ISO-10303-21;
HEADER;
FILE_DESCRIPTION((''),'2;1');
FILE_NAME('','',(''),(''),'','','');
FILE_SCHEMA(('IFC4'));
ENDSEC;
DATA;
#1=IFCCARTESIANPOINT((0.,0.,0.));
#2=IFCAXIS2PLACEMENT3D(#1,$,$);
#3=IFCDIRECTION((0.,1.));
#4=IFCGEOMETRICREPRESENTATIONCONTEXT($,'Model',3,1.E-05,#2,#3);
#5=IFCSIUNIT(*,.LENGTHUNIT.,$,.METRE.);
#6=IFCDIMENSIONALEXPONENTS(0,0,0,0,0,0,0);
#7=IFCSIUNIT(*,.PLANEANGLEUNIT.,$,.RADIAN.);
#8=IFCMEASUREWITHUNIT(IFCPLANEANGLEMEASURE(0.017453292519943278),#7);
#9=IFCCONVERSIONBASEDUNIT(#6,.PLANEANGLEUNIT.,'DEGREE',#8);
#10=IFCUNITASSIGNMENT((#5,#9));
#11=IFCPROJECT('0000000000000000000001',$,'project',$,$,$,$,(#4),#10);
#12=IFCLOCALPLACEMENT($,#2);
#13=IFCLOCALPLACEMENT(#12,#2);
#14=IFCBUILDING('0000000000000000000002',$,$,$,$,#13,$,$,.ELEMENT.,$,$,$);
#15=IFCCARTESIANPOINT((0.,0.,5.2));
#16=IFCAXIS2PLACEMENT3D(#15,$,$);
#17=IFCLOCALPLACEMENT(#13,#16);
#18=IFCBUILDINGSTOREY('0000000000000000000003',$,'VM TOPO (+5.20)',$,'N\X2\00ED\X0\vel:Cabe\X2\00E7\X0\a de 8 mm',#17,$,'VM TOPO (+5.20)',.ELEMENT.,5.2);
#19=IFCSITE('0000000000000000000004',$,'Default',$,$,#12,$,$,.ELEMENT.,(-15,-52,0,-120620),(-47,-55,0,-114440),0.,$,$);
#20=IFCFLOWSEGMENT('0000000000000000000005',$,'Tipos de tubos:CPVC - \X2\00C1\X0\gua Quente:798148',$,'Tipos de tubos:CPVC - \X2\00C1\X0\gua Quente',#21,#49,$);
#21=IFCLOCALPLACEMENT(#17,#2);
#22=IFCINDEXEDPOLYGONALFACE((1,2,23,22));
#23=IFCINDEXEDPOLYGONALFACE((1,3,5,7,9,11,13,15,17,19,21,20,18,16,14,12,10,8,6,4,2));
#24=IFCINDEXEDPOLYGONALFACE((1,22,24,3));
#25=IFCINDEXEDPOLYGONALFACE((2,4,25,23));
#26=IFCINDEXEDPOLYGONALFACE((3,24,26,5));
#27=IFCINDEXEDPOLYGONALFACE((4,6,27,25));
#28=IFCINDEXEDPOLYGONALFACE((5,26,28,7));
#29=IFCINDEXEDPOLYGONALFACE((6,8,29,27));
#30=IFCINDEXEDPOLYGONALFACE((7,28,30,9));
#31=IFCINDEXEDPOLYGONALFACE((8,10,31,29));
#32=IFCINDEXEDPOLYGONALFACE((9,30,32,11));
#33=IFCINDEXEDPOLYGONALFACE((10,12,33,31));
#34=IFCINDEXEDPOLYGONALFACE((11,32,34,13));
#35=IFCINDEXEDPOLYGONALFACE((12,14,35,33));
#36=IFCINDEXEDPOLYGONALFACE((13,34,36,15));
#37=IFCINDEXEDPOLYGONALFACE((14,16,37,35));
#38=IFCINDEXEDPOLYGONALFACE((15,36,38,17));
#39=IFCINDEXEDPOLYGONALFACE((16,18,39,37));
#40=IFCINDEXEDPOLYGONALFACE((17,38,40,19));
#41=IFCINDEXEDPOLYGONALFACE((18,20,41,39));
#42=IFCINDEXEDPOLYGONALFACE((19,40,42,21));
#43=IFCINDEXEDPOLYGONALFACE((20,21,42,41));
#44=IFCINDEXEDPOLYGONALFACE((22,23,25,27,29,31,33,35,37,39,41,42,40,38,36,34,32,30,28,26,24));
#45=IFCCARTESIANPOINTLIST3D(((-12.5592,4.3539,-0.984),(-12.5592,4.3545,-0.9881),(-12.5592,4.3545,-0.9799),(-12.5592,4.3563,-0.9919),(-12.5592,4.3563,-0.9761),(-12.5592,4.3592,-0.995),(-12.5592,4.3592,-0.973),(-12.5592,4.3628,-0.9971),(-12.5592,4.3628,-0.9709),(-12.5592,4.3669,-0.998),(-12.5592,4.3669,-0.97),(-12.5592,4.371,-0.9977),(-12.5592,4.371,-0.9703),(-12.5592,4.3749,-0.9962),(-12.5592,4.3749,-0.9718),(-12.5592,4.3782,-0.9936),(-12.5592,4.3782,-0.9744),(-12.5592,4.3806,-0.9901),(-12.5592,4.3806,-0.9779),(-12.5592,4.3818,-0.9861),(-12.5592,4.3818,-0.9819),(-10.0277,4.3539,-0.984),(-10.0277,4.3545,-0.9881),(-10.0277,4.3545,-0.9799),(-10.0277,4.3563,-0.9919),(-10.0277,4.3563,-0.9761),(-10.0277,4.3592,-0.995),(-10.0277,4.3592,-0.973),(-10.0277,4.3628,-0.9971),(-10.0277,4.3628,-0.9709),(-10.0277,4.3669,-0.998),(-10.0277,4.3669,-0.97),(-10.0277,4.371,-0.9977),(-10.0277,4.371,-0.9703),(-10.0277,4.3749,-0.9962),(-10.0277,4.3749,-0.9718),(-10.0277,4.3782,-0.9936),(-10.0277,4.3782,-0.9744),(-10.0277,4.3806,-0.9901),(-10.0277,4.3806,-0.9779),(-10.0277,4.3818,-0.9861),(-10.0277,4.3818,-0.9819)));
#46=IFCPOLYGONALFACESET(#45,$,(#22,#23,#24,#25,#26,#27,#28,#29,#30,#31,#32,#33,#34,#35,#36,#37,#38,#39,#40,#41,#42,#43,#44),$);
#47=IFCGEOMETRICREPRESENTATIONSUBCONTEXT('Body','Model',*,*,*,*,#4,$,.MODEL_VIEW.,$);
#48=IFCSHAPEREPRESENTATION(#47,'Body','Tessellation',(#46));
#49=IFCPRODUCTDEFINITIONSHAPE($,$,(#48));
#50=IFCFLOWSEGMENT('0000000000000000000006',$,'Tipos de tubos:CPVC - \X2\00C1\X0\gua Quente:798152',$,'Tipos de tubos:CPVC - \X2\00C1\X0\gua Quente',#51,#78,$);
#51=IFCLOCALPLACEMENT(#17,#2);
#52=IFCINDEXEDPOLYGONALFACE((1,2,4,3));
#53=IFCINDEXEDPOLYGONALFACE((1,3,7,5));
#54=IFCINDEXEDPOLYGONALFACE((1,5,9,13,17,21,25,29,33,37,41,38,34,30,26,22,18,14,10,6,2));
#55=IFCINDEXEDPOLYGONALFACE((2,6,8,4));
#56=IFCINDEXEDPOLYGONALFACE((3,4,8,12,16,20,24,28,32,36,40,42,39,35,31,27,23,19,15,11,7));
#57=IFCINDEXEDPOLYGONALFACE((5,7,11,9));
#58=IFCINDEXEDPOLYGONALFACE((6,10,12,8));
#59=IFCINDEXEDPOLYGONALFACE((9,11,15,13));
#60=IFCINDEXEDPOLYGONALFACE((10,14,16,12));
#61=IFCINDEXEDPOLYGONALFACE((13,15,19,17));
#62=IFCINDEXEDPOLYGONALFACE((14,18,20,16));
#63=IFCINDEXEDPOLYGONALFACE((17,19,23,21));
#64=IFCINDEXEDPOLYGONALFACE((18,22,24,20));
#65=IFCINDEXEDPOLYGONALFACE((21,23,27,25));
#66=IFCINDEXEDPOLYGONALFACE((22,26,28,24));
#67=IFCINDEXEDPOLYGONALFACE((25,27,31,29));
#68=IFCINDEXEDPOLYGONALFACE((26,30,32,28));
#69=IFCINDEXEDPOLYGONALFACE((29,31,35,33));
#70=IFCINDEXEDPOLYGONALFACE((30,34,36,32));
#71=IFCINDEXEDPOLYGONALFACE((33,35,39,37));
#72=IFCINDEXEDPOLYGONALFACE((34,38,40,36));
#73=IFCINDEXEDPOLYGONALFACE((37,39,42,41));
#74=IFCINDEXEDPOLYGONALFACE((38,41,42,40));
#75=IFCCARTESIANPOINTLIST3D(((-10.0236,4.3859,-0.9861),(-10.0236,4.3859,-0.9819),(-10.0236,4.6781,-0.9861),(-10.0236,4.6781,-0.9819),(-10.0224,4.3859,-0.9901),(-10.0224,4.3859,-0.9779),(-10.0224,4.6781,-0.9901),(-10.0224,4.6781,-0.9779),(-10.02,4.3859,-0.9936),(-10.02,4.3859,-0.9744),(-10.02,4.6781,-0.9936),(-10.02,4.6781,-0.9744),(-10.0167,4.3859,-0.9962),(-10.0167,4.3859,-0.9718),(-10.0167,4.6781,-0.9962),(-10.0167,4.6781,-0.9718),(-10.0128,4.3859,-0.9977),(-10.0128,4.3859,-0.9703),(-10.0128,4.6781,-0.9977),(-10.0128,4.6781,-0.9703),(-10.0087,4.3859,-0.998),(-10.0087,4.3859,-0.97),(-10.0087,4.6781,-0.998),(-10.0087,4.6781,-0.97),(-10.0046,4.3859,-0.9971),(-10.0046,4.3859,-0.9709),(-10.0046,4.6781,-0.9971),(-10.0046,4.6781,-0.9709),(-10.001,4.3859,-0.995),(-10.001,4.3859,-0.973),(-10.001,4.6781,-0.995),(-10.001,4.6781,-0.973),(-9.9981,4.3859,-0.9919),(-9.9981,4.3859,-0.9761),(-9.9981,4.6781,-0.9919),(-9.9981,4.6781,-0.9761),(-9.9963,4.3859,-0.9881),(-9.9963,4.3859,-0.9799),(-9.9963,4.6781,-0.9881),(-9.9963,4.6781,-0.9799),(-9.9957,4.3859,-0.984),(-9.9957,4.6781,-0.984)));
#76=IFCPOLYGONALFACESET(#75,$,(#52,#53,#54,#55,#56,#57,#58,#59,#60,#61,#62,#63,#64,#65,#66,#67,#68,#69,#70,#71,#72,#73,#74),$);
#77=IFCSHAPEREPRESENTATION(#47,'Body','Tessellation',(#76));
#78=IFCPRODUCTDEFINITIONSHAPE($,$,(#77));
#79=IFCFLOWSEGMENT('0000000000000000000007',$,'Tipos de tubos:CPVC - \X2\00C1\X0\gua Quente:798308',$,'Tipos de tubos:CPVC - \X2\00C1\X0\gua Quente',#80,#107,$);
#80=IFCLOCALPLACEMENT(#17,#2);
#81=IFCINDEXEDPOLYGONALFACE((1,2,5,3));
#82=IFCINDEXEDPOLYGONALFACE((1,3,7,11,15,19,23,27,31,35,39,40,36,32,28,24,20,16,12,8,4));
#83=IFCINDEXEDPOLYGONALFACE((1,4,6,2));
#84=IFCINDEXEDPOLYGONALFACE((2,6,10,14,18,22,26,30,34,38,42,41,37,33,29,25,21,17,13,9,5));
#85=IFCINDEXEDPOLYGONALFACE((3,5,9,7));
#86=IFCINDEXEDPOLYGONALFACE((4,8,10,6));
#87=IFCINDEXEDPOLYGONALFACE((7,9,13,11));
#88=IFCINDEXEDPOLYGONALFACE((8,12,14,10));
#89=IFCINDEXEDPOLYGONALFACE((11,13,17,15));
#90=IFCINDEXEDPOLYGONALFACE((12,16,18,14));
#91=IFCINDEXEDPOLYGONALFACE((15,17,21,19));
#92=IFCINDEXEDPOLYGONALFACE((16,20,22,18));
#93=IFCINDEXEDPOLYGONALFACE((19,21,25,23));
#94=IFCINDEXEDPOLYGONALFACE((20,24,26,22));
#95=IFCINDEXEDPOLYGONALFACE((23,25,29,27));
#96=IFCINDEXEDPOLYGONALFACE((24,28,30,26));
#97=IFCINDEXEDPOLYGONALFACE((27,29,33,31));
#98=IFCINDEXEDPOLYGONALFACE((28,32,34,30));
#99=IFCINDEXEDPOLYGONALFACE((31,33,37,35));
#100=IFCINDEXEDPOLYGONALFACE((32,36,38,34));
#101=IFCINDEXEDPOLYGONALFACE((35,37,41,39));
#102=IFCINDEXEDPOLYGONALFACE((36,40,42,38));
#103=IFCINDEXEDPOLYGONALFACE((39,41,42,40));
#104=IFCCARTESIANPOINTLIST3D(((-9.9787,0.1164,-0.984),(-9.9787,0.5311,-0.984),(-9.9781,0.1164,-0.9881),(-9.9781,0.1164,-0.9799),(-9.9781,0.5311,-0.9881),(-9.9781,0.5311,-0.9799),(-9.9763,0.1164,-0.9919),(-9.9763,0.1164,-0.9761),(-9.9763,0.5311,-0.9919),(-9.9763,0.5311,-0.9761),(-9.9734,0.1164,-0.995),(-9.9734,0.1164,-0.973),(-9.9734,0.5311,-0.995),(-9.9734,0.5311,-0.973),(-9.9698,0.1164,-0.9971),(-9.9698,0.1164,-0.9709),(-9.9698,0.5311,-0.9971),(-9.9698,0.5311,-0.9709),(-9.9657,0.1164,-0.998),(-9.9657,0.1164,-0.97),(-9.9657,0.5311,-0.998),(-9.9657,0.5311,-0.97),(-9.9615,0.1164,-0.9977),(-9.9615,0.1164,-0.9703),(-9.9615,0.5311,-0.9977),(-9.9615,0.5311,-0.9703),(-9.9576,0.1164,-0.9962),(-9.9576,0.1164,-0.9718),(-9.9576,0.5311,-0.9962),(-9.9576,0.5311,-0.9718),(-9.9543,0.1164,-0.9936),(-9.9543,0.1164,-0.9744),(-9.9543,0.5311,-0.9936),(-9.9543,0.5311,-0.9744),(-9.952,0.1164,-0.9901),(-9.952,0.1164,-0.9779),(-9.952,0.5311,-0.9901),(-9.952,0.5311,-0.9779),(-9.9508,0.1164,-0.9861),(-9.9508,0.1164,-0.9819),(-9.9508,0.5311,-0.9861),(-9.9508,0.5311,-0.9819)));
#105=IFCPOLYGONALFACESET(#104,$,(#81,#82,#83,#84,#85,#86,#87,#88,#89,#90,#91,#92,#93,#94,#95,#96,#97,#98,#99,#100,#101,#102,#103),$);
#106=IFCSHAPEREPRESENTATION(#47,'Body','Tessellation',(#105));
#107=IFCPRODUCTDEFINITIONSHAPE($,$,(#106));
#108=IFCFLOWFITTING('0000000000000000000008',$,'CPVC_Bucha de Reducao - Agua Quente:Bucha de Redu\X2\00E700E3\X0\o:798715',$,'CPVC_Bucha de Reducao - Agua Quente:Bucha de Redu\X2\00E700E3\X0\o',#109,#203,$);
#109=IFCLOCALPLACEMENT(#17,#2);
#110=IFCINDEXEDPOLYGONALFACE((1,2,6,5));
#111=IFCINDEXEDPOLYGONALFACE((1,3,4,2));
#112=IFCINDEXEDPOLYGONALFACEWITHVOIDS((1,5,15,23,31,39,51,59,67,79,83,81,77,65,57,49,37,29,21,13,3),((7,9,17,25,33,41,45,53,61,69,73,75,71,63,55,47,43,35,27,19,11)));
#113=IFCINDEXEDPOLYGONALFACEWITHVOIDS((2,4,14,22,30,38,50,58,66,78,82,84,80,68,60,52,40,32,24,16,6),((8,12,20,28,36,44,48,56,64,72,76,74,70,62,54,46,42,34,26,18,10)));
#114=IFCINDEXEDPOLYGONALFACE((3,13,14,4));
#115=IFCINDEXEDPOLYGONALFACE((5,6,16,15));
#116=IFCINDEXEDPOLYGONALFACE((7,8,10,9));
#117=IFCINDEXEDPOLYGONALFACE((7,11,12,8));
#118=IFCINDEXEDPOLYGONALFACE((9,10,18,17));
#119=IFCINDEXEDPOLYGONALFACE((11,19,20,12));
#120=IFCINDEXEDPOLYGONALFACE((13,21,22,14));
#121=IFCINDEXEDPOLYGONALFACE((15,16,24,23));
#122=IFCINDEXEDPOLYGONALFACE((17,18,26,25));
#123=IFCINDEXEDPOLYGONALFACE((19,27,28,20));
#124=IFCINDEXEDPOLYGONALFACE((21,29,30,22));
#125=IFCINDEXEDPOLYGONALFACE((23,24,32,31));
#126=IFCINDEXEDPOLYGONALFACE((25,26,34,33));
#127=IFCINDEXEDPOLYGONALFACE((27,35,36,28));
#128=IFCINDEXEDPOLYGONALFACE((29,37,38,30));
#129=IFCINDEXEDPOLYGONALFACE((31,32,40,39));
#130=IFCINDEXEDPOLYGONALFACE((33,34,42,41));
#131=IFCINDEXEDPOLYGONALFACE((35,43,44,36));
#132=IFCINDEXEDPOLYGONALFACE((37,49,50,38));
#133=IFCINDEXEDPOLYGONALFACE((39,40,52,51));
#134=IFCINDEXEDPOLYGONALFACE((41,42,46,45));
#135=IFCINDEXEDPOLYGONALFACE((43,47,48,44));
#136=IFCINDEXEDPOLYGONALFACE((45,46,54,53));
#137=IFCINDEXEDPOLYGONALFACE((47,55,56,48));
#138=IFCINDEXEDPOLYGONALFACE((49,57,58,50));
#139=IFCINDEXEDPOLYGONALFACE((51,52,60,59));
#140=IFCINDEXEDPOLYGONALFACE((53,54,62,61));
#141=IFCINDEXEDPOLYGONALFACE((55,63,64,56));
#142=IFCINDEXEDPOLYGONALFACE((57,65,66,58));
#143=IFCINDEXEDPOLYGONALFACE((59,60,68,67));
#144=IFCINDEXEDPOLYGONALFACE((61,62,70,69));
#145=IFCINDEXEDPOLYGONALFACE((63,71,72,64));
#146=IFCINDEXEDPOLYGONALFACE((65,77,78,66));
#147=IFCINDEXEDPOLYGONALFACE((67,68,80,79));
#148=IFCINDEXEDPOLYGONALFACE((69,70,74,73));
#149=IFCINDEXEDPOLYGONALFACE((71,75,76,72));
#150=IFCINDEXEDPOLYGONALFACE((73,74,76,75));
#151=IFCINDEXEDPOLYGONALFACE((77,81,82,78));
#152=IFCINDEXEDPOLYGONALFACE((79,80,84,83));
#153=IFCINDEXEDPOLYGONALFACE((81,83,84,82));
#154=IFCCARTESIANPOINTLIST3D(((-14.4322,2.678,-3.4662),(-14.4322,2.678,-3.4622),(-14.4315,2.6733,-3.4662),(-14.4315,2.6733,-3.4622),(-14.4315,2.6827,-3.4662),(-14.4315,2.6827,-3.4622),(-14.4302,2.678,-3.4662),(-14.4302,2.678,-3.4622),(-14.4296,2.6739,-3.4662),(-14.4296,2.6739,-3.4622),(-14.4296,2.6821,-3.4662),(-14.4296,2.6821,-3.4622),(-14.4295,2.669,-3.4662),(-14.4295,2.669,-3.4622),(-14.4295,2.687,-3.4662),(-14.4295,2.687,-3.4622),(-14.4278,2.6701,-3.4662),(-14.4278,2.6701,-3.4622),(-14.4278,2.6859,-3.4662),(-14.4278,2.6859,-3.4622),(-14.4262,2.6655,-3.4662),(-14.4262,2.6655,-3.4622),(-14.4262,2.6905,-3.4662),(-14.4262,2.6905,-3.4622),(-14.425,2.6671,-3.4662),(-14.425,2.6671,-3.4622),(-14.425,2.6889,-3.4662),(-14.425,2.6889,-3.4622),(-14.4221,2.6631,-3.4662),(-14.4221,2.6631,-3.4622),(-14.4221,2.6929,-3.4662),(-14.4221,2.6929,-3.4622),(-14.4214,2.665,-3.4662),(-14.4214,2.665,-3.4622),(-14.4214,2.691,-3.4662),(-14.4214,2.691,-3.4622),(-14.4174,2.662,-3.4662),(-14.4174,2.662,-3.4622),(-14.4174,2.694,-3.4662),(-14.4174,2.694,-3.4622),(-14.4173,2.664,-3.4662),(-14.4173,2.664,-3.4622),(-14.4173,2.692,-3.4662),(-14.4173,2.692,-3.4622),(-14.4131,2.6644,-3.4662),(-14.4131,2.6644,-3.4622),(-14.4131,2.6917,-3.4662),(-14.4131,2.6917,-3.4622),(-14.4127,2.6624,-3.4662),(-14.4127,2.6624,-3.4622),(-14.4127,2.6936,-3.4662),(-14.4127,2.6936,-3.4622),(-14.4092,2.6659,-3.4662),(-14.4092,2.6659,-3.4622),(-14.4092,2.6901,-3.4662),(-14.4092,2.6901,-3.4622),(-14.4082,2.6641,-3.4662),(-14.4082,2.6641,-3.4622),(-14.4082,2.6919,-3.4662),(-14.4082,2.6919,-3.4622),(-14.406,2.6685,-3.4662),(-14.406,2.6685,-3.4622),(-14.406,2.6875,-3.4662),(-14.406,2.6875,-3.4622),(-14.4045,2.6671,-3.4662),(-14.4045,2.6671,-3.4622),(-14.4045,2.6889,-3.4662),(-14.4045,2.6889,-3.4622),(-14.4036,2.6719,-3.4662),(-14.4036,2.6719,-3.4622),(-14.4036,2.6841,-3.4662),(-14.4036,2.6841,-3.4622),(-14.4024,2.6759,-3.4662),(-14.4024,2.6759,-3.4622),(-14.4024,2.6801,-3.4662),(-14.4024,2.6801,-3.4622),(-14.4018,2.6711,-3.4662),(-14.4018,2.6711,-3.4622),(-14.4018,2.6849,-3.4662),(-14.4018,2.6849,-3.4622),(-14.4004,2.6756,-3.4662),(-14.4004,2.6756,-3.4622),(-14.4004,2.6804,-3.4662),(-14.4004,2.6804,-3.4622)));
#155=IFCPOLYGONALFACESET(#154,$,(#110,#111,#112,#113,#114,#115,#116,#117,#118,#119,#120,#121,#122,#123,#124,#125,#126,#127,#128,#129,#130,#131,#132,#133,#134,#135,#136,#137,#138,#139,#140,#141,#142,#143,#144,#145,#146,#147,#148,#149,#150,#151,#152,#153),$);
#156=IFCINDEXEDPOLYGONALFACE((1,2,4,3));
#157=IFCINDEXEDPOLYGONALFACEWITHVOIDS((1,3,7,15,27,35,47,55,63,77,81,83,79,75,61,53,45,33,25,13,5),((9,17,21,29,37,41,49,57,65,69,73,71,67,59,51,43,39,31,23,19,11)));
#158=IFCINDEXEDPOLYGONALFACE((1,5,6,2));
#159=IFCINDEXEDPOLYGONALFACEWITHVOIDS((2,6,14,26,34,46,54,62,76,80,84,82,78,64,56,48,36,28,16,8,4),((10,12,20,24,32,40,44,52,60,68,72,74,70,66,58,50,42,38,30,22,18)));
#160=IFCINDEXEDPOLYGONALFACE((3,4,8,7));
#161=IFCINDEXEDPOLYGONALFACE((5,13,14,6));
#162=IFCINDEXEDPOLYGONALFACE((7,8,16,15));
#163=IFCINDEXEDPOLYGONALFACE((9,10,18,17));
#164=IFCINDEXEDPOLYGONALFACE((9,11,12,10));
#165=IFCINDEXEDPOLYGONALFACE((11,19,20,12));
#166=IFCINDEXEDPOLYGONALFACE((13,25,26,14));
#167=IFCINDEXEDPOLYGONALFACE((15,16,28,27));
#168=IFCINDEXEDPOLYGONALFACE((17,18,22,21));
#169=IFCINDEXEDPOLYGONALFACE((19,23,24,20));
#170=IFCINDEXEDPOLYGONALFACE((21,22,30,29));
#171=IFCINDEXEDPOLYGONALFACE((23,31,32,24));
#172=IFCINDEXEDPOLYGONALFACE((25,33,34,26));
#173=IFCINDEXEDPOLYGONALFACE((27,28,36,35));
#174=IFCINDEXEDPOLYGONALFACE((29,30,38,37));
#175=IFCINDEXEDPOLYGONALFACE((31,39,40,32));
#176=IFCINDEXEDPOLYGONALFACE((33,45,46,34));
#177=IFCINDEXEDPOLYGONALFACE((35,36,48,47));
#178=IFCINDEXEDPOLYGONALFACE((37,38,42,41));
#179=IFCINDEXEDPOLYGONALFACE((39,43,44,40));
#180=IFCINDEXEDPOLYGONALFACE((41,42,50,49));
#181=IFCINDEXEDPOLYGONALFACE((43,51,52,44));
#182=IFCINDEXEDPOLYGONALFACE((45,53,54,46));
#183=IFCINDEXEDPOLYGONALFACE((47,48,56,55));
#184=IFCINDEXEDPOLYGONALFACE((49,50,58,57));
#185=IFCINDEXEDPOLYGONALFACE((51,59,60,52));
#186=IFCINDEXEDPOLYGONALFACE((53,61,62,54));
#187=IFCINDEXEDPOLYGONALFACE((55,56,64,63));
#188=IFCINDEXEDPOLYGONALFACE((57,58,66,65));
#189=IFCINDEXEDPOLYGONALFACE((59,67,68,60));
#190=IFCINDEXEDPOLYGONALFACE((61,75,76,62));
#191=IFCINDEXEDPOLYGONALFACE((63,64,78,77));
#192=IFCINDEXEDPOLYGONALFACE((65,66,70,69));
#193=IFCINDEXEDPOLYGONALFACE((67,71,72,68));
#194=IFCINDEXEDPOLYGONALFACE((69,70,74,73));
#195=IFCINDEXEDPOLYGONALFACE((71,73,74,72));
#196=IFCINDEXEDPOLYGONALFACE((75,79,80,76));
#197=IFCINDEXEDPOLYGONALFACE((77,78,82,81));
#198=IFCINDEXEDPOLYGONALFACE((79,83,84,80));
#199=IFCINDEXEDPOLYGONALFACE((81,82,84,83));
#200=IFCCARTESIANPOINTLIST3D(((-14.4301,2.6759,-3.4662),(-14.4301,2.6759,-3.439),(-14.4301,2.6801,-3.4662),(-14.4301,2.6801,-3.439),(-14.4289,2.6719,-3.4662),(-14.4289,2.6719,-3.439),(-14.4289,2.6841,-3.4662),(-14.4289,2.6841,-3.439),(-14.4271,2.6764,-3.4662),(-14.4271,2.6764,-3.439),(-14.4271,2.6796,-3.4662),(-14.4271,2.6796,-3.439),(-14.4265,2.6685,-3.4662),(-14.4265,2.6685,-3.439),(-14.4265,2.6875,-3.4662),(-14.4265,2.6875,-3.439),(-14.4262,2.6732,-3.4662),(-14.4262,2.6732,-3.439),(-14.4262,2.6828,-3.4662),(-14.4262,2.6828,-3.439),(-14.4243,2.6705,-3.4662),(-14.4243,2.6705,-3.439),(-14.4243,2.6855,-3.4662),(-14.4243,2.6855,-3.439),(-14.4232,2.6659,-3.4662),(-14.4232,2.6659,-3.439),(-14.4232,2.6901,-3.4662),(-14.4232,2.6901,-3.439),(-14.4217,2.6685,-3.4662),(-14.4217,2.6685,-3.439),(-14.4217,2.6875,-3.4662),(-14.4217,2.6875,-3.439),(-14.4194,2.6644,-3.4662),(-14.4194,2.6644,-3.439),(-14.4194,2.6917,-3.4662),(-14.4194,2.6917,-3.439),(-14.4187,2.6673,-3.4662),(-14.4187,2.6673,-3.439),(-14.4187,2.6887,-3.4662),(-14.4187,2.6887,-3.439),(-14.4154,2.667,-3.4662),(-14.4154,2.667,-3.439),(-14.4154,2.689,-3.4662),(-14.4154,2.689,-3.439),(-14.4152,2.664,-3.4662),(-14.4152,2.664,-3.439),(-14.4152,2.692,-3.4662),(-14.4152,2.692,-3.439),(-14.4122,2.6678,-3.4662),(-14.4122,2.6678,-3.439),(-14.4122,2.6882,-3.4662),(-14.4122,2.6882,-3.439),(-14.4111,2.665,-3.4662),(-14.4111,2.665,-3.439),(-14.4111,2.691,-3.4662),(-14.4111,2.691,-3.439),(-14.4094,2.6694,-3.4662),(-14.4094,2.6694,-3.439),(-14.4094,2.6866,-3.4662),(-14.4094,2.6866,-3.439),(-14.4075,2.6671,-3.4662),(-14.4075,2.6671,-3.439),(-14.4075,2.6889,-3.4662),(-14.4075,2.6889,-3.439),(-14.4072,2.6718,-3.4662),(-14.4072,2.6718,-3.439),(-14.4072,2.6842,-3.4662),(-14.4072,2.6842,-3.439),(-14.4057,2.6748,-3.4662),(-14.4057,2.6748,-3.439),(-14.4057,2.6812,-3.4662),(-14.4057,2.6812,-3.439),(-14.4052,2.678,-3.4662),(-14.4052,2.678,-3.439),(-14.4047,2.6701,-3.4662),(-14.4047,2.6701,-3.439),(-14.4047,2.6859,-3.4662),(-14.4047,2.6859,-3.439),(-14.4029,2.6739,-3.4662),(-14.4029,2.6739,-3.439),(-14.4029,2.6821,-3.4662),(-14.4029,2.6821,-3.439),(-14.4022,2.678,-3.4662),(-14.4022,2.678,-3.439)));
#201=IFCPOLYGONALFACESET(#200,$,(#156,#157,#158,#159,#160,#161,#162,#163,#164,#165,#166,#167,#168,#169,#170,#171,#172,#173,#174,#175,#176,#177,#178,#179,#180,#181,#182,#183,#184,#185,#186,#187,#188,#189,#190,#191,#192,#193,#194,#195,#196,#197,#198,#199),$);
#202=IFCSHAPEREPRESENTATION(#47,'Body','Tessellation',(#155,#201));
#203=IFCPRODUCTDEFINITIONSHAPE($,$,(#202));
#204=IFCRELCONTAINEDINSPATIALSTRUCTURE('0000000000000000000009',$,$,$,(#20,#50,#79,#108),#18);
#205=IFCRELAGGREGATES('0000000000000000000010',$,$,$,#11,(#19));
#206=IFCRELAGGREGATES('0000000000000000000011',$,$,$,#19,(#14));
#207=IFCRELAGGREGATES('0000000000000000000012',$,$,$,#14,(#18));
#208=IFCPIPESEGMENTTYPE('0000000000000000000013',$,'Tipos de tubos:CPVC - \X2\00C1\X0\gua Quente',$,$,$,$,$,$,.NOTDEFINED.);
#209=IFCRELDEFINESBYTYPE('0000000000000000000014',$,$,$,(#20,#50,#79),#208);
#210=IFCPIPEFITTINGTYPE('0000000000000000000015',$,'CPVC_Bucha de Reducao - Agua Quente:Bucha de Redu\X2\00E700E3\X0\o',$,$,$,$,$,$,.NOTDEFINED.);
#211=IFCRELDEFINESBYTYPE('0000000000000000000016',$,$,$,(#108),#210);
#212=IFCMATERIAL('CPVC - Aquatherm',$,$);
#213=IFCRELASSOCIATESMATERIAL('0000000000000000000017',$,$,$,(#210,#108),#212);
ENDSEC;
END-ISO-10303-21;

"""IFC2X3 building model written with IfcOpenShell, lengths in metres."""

from ifc_helpers import new_model, entity, si_unit, converted_unit, direction, frame, frame_2d, origin, origin_2d_with_axis, place, context, subcontext, project, spatial, circle, hollow_circle, extrude, source, transform, mapped, material, type_object, type_shapes, element, save


model = new_model("IFC2X3")

# Units and contexts
model_context = context("Model", 3, precision=1e-05, world=origin(), true_north=direction((0.0, 1.0)))
body_context = subcontext(model_context, "Body", "Model", "MODEL_VIEW")
ifc_project = project(units=[si_unit("LENGTHUNIT", "METRE"), converted_unit("PLANEANGLEUNIT", "DEGREE", entity("IfcPlaneAngleMeasure", 0.017453292519943278), si_unit("PLANEANGLEUNIT", "RADIAN"), dimensions=[0, 0, 0, 0, 0, 0, 0])], contexts=[model_context])

# Site, building, storey
site_placement = place(None, origin())
site = spatial("IfcSite", under=ifc_project, at=site_placement, Name="Default", CompositionType="ELEMENT", RefLatitude=(-15, -52, 0, -120620), RefLongitude=(-47, -55, 0, -114440), RefElevation=0.0)
building_placement = place(site_placement, origin())
building = spatial("IfcBuilding", under=site, at=building_placement, CompositionType="ELEMENT")
storey_placement = place(building_placement, frame((0.0, 0.0, 5.2)))
storey = spatial("IfcBuildingStorey", under=building, at=storey_placement, Name="VM TOPO (+5.20)", ObjectType="Nível:Cabeça de 8 mm", LongName="VM TOPO (+5.20)", CompositionType="ELEMENT", Elevation=5.2)

# Flow segments
pipe_segment_type_1 = type_object("IfcPipeSegmentType", Name="Tipos de tubos:CPVC - Água Quente", PredefinedType="NOTDEFINED")
flow_segment_1_placement = place(storey_placement, origin())
element("IfcFlowSegment", 1, at=flow_segment_1_placement, inside=storey, type_object=pipe_segment_type_1, Name="Tipos de tubos:CPVC - Água Quente:798148", ObjectType="Tipos de tubos:CPVC - Água Quente", context=body_context, shape_type="SweptSolid", body=[
    extrude(circle(Radius=0.0141, at=origin_2d_with_axis()), frame((-12.5592, 4.3679, -0.984), z_axis=(1.0, 0.0, 0.0), x_axis=(0.0, -1.0, 0.0)), (0.0, 0.0, 1.0), 2.5315),
])
flow_segment_2_placement = place(storey_placement, origin())
element("IfcFlowSegment", 2, at=flow_segment_2_placement, inside=storey, type_object=pipe_segment_type_1, Name="Tipos de tubos:CPVC - Água Quente:798152", ObjectType="Tipos de tubos:CPVC - Água Quente", context=body_context, shape_type="SweptSolid", body=[
    extrude(circle(Radius=0.0141, at=origin_2d_with_axis()), frame((-10.0097, 4.3859, -0.984), z_axis=(0.0, 1.0, 0.0), x_axis=(1.0, 0.0, 0.0)), (0.0, 0.0, 1.0), 0.2922),
])
flow_segment_3_placement = place(storey_placement, origin())
element("IfcFlowSegment", 3, at=flow_segment_3_placement, inside=storey, type_object=pipe_segment_type_1, Name="Tipos de tubos:CPVC - Água Quente:798308", ObjectType="Tipos de tubos:CPVC - Água Quente", context=body_context, shape_type="SweptSolid", body=[
    extrude(circle(Radius=0.0141, at=origin_2d_with_axis()), frame((-9.9646, 0.1164, -0.984), z_axis=(0.0, 1.0, 0.0), x_axis=(-1.0, 0.0, 0.0)), (0.0, 0.0, 1.0), 0.4147),
])

# Flow fitting
ifc_material_1 = material(Name="CPVC - Aquatherm")
pipe_fitting_type_1 = type_object("IfcPipeFittingType", Name="CPVC_Bucha de Reducao - Agua Quente:Bucha de Redução", PredefinedType="NOTDEFINED", material=ifc_material_1)
shared_shape_1 = source(origin(), body_context, "Body", "SweptSolid", [
    extrude(hollow_circle(Radius=0.016, WallThickness=0.002, at=frame_2d((0.0, 0.0), x_axis=(1.0, 0.0))), frame((0.0232, 0.0, 0.0), z_axis=(1.0, 0.0, 0.0), x_axis=(0.0, 1.0, 0.0)), (0.0, 0.0, 1.0), 0.004),
    extrude(hollow_circle(Radius=0.014, WallThickness=0.003, at=frame_2d((0.0, 0.0), x_axis=(1.0, 0.0))), frame((0.0, 0.0, 0.0), z_axis=(1.0, 0.0, 0.0), x_axis=(0.0, -1.0, 0.0)), (0.0, 0.0, 1.0), 0.0272),
])
type_shapes(pipe_fitting_type_1, [shared_shape_1])
flow_fitting_1_placement = place(storey_placement, frame((-14.4162, 2.678, -3.439), z_axis=(0.0, 1.0, 0.0), x_axis=(0.0, 0.0, -1.0)))
element("IfcFlowFitting", 4, at=flow_fitting_1_placement, inside=storey, type_object=pipe_fitting_type_1, material=ifc_material_1, Name="CPVC_Bucha de Reducao - Agua Quente:Bucha de Redução:798715", ObjectType="CPVC_Bucha de Reducao - Agua Quente:Bucha de Redução", context=body_context, shape_type="MappedRepresentation", body=[
    mapped(shared_shape_1, transform((0.0, 0.0, 0.0), scale=1.0)),
])

save(model, "model.ifc")
